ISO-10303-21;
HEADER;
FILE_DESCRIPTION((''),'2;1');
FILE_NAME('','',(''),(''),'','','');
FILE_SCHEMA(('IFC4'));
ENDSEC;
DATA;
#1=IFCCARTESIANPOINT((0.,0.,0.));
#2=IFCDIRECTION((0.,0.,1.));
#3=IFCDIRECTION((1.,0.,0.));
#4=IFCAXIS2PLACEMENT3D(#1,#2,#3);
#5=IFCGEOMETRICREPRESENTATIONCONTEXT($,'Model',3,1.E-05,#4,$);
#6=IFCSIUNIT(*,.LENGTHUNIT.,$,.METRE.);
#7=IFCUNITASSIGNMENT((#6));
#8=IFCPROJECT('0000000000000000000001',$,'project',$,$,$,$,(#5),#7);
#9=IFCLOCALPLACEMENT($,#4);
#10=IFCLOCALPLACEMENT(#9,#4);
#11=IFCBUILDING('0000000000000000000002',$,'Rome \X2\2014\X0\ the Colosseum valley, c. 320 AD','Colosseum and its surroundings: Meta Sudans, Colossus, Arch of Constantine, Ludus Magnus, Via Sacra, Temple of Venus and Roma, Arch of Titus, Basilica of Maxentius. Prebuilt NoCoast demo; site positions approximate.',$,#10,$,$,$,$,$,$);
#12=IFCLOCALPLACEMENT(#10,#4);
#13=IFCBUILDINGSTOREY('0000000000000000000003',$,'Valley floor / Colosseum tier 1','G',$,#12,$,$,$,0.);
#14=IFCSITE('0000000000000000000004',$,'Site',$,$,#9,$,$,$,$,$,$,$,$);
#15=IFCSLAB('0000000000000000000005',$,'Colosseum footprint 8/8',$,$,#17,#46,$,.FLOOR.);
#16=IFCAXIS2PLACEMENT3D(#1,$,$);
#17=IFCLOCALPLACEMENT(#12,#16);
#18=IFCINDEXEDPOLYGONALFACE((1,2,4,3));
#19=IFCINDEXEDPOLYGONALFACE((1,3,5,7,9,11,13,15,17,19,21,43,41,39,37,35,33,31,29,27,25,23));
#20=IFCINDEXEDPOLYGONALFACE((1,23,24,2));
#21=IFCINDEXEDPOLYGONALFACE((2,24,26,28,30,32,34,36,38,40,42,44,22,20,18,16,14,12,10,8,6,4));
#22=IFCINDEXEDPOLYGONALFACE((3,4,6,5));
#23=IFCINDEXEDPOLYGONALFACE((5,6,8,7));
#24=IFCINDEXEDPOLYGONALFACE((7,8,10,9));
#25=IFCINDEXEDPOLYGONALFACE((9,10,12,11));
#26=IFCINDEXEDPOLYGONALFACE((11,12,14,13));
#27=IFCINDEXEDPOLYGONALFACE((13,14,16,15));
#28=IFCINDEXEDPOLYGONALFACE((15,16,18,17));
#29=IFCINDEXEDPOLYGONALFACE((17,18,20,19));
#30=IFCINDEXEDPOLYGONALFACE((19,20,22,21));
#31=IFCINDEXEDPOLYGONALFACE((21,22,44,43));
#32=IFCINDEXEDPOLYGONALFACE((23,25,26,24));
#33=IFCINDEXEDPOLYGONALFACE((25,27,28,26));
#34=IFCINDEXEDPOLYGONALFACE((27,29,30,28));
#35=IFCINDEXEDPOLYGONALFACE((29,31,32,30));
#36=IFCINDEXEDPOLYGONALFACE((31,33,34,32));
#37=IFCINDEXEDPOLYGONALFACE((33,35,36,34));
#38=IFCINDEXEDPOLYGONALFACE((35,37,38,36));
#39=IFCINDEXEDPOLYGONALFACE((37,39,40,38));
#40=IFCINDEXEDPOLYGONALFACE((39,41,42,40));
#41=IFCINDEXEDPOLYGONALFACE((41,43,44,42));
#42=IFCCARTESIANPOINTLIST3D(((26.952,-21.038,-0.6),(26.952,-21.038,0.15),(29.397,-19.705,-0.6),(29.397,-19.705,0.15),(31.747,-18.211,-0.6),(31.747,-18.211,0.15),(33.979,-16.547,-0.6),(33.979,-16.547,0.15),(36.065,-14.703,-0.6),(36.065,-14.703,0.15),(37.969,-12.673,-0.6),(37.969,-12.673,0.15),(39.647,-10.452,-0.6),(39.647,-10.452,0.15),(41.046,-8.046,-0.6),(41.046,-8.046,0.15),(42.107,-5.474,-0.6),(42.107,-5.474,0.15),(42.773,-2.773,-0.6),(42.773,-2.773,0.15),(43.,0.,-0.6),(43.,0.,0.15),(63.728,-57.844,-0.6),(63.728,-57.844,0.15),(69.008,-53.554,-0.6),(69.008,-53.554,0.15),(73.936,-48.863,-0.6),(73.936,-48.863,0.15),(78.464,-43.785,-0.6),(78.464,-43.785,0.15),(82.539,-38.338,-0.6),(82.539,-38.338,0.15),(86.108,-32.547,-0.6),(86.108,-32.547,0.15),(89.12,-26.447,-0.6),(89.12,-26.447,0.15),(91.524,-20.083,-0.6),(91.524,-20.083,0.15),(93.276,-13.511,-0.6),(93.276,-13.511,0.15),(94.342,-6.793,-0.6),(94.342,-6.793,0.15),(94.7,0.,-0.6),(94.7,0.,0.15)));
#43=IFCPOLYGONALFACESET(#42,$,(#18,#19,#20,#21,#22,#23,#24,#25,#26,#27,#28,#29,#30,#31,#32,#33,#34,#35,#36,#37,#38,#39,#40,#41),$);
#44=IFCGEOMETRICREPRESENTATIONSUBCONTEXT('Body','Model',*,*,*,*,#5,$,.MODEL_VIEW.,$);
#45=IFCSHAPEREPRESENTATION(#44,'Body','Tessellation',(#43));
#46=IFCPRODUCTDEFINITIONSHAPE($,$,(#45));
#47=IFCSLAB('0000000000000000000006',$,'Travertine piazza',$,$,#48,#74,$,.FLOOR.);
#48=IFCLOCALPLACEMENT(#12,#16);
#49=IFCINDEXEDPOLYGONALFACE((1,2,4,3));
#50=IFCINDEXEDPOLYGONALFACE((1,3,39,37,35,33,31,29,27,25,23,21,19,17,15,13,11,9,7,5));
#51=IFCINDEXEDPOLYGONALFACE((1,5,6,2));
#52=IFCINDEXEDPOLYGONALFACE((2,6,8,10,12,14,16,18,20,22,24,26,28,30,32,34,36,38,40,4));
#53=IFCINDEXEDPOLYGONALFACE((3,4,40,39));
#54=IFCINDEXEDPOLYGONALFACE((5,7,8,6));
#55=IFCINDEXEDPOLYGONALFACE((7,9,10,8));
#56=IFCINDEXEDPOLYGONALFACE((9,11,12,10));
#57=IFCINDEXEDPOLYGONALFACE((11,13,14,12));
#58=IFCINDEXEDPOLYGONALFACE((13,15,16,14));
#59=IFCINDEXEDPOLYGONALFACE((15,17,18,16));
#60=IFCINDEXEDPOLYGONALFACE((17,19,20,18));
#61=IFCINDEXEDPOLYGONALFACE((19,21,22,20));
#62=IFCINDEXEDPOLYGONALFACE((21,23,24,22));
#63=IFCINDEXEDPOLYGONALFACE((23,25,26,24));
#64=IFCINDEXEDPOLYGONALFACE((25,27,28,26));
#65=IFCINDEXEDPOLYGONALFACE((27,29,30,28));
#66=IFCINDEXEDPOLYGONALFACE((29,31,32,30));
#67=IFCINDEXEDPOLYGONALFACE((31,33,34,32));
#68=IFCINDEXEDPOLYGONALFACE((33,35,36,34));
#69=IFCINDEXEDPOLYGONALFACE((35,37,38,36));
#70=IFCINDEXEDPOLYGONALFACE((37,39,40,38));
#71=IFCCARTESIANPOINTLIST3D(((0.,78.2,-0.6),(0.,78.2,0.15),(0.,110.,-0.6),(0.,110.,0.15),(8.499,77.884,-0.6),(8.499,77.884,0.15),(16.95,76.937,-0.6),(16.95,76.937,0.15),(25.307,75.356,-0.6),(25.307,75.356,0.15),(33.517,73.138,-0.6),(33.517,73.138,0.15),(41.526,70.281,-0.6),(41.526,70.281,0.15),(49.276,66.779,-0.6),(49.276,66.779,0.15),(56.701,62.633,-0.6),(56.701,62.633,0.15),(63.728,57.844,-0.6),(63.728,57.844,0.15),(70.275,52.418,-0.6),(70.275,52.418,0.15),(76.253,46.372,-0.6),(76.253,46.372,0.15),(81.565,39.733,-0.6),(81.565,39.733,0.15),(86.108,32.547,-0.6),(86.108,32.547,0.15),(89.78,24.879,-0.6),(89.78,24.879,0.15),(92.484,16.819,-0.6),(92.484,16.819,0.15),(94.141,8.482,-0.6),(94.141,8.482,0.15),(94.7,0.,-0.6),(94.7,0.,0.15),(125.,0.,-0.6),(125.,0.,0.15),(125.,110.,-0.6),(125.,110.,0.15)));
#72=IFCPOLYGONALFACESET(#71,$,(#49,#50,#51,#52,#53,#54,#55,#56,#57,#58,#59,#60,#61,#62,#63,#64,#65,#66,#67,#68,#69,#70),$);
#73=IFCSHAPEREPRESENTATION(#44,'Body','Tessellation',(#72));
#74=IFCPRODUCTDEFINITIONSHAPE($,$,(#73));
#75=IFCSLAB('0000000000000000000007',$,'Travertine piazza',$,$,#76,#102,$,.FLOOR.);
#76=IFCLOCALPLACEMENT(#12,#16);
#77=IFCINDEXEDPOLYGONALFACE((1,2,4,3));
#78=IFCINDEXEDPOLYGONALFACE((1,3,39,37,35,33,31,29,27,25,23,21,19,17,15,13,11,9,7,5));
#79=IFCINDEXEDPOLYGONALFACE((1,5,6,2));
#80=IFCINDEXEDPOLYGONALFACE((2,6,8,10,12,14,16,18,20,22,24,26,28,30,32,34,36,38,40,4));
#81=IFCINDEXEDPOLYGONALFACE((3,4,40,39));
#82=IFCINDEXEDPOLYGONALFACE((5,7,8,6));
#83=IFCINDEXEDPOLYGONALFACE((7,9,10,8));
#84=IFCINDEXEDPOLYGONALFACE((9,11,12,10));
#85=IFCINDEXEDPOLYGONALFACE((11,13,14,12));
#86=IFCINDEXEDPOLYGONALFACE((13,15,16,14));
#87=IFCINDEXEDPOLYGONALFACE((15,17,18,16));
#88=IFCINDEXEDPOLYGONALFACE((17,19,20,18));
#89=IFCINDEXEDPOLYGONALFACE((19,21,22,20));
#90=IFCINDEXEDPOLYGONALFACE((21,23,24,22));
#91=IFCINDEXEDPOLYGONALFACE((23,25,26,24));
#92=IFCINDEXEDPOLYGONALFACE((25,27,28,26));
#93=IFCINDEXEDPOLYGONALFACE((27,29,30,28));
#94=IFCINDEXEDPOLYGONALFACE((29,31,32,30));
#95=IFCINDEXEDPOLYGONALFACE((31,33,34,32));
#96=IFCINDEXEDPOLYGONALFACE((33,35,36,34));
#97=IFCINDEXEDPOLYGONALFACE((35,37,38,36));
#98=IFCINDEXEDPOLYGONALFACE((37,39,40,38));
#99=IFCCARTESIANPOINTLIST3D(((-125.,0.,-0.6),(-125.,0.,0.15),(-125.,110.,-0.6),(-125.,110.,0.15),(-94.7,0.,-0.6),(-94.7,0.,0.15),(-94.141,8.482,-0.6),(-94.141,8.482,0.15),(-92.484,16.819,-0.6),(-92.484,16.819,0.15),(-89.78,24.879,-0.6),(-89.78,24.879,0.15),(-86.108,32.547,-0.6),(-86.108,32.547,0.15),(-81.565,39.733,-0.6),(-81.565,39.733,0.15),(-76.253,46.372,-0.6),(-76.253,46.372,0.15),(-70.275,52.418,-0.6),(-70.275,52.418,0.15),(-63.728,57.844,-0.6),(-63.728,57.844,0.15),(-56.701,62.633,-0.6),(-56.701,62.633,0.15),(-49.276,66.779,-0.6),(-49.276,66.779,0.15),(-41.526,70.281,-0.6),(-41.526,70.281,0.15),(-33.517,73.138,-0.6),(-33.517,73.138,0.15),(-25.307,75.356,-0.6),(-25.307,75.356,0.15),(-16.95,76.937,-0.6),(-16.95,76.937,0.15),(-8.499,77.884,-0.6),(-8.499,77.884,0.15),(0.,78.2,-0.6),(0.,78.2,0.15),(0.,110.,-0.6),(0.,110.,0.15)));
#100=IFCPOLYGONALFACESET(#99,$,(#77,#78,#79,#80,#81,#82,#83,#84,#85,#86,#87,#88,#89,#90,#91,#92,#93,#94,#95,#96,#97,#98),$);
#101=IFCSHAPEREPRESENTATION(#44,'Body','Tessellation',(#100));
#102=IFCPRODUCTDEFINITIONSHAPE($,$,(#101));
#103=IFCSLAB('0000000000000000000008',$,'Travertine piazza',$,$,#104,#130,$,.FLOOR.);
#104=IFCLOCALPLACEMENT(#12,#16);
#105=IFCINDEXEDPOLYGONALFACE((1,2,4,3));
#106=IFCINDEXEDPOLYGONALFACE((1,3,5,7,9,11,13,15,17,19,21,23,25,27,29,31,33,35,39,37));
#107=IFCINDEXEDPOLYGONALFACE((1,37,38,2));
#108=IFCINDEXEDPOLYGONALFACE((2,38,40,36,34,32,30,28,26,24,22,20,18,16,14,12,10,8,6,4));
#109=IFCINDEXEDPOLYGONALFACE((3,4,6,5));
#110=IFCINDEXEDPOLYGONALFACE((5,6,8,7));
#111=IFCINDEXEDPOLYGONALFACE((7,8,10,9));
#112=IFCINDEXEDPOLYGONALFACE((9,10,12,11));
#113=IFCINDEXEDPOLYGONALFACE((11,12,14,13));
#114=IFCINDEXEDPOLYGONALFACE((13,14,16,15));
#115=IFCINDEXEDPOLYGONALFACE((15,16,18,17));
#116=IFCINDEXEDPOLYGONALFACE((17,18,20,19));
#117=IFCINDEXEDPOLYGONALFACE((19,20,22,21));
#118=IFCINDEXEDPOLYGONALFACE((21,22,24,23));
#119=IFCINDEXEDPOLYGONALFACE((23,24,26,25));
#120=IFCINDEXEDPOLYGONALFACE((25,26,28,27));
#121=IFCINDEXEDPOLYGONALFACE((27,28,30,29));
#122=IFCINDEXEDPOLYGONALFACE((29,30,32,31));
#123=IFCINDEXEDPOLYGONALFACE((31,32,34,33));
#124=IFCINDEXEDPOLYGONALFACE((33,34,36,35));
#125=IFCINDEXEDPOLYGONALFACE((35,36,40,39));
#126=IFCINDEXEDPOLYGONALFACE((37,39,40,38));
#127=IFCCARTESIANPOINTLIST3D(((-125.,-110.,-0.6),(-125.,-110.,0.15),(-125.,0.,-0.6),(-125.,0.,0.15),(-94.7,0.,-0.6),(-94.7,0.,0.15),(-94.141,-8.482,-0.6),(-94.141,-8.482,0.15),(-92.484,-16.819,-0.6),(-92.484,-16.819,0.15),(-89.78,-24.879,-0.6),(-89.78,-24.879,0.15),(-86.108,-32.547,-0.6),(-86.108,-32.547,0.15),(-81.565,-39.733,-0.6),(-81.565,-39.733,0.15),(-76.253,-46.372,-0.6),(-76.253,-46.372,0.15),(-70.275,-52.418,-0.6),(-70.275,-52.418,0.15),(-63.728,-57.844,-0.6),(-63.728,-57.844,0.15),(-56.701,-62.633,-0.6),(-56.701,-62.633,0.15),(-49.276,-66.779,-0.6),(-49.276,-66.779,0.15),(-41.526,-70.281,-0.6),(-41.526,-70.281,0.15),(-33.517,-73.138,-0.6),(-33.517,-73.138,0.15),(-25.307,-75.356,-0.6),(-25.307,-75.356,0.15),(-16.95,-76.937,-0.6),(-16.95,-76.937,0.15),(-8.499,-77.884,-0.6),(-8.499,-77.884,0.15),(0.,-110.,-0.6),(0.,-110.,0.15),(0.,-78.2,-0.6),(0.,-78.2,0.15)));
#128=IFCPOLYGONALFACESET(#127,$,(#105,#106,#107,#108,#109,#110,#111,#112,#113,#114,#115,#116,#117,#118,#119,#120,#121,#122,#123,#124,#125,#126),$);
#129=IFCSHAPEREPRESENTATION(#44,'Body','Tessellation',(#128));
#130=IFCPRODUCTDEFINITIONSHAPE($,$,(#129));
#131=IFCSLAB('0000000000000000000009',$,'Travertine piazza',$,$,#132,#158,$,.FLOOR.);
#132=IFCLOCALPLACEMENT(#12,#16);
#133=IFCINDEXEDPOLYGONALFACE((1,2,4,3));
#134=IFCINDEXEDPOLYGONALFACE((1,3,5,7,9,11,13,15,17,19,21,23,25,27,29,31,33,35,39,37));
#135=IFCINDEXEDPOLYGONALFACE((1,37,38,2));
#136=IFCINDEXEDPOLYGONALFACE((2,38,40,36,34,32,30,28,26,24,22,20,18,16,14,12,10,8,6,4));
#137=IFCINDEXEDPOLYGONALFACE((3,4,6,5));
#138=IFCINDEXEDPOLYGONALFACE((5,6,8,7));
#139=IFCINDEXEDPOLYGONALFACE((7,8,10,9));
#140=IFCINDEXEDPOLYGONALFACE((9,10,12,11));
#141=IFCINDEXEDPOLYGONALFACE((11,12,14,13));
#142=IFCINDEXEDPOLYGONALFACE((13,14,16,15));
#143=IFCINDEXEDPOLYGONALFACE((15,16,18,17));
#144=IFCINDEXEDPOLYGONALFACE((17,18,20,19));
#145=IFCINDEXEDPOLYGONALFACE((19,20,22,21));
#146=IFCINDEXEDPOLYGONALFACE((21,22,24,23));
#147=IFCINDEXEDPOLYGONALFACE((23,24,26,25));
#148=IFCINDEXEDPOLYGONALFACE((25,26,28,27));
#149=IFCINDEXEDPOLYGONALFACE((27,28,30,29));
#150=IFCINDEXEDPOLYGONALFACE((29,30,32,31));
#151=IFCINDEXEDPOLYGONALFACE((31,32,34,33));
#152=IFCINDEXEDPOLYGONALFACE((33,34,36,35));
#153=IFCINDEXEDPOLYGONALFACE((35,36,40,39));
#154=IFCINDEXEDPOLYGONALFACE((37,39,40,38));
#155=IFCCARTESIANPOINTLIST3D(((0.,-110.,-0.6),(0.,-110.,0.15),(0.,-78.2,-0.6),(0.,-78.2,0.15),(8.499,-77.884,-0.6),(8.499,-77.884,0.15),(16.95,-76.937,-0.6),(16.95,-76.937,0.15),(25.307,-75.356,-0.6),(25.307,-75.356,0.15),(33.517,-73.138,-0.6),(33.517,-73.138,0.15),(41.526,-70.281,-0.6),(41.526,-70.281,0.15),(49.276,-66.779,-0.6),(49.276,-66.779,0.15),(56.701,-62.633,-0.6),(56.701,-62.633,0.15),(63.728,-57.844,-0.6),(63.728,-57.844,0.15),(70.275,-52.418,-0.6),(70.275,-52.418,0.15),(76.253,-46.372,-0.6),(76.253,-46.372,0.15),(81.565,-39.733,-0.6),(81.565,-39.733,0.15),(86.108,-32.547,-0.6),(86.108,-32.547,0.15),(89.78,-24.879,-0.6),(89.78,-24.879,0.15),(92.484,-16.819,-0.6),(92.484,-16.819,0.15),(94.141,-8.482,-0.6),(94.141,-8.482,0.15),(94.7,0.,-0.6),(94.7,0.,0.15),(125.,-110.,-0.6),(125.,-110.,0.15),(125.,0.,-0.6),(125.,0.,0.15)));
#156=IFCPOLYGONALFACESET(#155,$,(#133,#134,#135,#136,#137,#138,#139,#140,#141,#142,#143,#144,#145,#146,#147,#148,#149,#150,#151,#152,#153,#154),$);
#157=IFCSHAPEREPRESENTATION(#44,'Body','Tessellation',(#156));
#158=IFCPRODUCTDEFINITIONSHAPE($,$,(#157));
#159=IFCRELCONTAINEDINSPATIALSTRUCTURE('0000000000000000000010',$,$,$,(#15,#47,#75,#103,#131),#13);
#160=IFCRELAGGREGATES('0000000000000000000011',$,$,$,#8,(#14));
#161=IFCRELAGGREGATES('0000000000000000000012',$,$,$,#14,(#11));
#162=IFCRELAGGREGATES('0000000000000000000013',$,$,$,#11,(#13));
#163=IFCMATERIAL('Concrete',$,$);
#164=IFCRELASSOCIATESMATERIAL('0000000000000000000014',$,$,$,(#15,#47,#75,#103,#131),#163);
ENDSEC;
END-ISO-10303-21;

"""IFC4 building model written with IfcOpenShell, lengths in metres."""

from ifc_helpers import new_model, si_unit, frame, origin_with_axes, place, context, subcontext, project, spatial, indexed_curve, outline, extrude, material, element, save


model = new_model("IFC4")

# Units and contexts
model_context = context("Model", 3, precision=1e-05, world=origin_with_axes())
body_context = subcontext(model_context, "Body", "Model", "MODEL_VIEW")
ifc_project = project(units=[si_unit("LENGTHUNIT", "METRE")], contexts=[model_context])

# Site, building, storey
site_placement = place(None, origin_with_axes())
site = spatial("IfcSite", under=ifc_project, at=site_placement, Name="Site")
building_placement = place(site_placement, origin_with_axes())
building = spatial("IfcBuilding", under=site, at=building_placement, Name="Rome — the Colosseum valley, c. 320 AD", Description="Colosseum and its surroundings: Meta Sudans, Colossus, Arch of Constantine, Ludus Magnus, Via Sacra, Temple of Venus and Roma, Arch of Titus, Basilica of Maxentius. Prebuilt NoCoast demo; site positions approximate.")
storey_placement = place(building_placement, origin_with_axes())
storey = spatial("IfcBuildingStorey", under=building, at=storey_placement, Name="Valley floor / Colosseum tier 1", Description="G", Elevation=0.0)

# Slabs
ifc_material_1 = material(Name="Concrete")
slab_1_placement = place(storey_placement, frame((0.0, 0.0, -0.6), z_axis=(0.0, 0.0, 1.0), x_axis=(1.0, 0.0, 0.0)))
element("IfcSlab", 1, at=slab_1_placement, inside=storey, material=ifc_material_1, Name="Colosseum footprint 8/8", PredefinedType="FLOOR", context=body_context, shape_type="SweptSolid", body=[
    extrude(outline(indexed_curve([(26.952, -21.038), (29.397, -19.705), (31.747, -18.211), (33.979, -16.547), (36.065, -14.703), (37.969, -12.673), (39.647, -10.452), (41.046, -8.046), (42.107, -5.474), (42.773, -2.773), (43.0, 0.0), (94.7, 0.0), (94.342, -6.793), (93.276, -13.511), (91.524, -20.083), (89.12, -26.447), (86.108, -32.547), (82.539, -38.338), (78.464, -43.785), (73.936, -48.863), (69.008, -53.554), (63.728, -57.844)])), None, (0.0, 0.0, 1.0), 0.75),
])
slab_2_placement = place(storey_placement, frame((0.0, 0.0, -0.6), z_axis=(0.0, 0.0, 1.0), x_axis=(1.0, 0.0, 0.0)))
element("IfcSlab", 2, at=slab_2_placement, inside=storey, material=ifc_material_1, Name="Travertine piazza", PredefinedType="FLOOR", context=body_context, shape_type="SweptSolid", body=[
    extrude(outline(indexed_curve([(94.7, 0.0), (94.141, 8.482), (92.484, 16.819), (89.78, 24.879), (86.108, 32.547), (81.565, 39.733), (76.253, 46.372), (70.275, 52.418), (63.728, 57.844), (56.701, 62.633), (49.276, 66.779), (41.526, 70.281), (33.517, 73.138), (25.307, 75.356), (16.95, 76.937), (8.499, 77.884), (0.0, 78.2), (0.0, 110.0), (125.0, 110.0), (125.0, 0.0)])), None, (0.0, 0.0, 1.0), 0.75),
])
slab_3_placement = place(storey_placement, frame((0.0, 0.0, -0.6), z_axis=(0.0, 0.0, 1.0), x_axis=(1.0, 0.0, 0.0)))
element("IfcSlab", 3, at=slab_3_placement, inside=storey, material=ifc_material_1, Name="Travertine piazza", PredefinedType="FLOOR", context=body_context, shape_type="SweptSolid", body=[
    extrude(outline(indexed_curve([(-94.7, 0.0), (-94.141, 8.482), (-92.484, 16.819), (-89.78, 24.879), (-86.108, 32.547), (-81.565, 39.733), (-76.253, 46.372), (-70.275, 52.418), (-63.728, 57.844), (-56.701, 62.633), (-49.276, 66.779), (-41.526, 70.281), (-33.517, 73.138), (-25.307, 75.356), (-16.95, 76.937), (-8.499, 77.884), (0.0, 78.2), (0.0, 110.0), (-125.0, 110.0), (-125.0, 0.0)])), None, (0.0, 0.0, 1.0), 0.75),
])
slab_4_placement = place(storey_placement, frame((0.0, 0.0, -0.6), z_axis=(0.0, 0.0, 1.0), x_axis=(1.0, 0.0, 0.0)))
element("IfcSlab", 4, at=slab_4_placement, inside=storey, material=ifc_material_1, Name="Travertine piazza", PredefinedType="FLOOR", context=body_context, shape_type="SweptSolid", body=[
    extrude(outline(indexed_curve([(-94.7, 0.0), (-94.141, -8.482), (-92.484, -16.819), (-89.78, -24.879), (-86.108, -32.547), (-81.565, -39.733), (-76.253, -46.372), (-70.275, -52.418), (-63.728, -57.844), (-56.701, -62.633), (-49.276, -66.779), (-41.526, -70.281), (-33.517, -73.138), (-25.307, -75.356), (-16.95, -76.937), (-8.499, -77.884), (0.0, -78.2), (0.0, -110.0), (-125.0, -110.0), (-125.0, 0.0)])), None, (0.0, 0.0, 1.0), 0.75),
])
slab_5_placement = place(storey_placement, frame((0.0, 0.0, -0.6), z_axis=(0.0, 0.0, 1.0), x_axis=(1.0, 0.0, 0.0)))
element("IfcSlab", 5, at=slab_5_placement, inside=storey, material=ifc_material_1, Name="Travertine piazza", PredefinedType="FLOOR", context=body_context, shape_type="SweptSolid", body=[
    extrude(outline(indexed_curve([(94.7, 0.0), (94.141, -8.482), (92.484, -16.819), (89.78, -24.879), (86.108, -32.547), (81.565, -39.733), (76.253, -46.372), (70.275, -52.418), (63.728, -57.844), (56.701, -62.633), (49.276, -66.779), (41.526, -70.281), (33.517, -73.138), (25.307, -75.356), (16.95, -76.937), (8.499, -77.884), (0.0, -78.2), (0.0, -110.0), (125.0, -110.0), (125.0, 0.0)])), None, (0.0, 0.0, 1.0), 0.75),
])

save(model, "model.ifc")
